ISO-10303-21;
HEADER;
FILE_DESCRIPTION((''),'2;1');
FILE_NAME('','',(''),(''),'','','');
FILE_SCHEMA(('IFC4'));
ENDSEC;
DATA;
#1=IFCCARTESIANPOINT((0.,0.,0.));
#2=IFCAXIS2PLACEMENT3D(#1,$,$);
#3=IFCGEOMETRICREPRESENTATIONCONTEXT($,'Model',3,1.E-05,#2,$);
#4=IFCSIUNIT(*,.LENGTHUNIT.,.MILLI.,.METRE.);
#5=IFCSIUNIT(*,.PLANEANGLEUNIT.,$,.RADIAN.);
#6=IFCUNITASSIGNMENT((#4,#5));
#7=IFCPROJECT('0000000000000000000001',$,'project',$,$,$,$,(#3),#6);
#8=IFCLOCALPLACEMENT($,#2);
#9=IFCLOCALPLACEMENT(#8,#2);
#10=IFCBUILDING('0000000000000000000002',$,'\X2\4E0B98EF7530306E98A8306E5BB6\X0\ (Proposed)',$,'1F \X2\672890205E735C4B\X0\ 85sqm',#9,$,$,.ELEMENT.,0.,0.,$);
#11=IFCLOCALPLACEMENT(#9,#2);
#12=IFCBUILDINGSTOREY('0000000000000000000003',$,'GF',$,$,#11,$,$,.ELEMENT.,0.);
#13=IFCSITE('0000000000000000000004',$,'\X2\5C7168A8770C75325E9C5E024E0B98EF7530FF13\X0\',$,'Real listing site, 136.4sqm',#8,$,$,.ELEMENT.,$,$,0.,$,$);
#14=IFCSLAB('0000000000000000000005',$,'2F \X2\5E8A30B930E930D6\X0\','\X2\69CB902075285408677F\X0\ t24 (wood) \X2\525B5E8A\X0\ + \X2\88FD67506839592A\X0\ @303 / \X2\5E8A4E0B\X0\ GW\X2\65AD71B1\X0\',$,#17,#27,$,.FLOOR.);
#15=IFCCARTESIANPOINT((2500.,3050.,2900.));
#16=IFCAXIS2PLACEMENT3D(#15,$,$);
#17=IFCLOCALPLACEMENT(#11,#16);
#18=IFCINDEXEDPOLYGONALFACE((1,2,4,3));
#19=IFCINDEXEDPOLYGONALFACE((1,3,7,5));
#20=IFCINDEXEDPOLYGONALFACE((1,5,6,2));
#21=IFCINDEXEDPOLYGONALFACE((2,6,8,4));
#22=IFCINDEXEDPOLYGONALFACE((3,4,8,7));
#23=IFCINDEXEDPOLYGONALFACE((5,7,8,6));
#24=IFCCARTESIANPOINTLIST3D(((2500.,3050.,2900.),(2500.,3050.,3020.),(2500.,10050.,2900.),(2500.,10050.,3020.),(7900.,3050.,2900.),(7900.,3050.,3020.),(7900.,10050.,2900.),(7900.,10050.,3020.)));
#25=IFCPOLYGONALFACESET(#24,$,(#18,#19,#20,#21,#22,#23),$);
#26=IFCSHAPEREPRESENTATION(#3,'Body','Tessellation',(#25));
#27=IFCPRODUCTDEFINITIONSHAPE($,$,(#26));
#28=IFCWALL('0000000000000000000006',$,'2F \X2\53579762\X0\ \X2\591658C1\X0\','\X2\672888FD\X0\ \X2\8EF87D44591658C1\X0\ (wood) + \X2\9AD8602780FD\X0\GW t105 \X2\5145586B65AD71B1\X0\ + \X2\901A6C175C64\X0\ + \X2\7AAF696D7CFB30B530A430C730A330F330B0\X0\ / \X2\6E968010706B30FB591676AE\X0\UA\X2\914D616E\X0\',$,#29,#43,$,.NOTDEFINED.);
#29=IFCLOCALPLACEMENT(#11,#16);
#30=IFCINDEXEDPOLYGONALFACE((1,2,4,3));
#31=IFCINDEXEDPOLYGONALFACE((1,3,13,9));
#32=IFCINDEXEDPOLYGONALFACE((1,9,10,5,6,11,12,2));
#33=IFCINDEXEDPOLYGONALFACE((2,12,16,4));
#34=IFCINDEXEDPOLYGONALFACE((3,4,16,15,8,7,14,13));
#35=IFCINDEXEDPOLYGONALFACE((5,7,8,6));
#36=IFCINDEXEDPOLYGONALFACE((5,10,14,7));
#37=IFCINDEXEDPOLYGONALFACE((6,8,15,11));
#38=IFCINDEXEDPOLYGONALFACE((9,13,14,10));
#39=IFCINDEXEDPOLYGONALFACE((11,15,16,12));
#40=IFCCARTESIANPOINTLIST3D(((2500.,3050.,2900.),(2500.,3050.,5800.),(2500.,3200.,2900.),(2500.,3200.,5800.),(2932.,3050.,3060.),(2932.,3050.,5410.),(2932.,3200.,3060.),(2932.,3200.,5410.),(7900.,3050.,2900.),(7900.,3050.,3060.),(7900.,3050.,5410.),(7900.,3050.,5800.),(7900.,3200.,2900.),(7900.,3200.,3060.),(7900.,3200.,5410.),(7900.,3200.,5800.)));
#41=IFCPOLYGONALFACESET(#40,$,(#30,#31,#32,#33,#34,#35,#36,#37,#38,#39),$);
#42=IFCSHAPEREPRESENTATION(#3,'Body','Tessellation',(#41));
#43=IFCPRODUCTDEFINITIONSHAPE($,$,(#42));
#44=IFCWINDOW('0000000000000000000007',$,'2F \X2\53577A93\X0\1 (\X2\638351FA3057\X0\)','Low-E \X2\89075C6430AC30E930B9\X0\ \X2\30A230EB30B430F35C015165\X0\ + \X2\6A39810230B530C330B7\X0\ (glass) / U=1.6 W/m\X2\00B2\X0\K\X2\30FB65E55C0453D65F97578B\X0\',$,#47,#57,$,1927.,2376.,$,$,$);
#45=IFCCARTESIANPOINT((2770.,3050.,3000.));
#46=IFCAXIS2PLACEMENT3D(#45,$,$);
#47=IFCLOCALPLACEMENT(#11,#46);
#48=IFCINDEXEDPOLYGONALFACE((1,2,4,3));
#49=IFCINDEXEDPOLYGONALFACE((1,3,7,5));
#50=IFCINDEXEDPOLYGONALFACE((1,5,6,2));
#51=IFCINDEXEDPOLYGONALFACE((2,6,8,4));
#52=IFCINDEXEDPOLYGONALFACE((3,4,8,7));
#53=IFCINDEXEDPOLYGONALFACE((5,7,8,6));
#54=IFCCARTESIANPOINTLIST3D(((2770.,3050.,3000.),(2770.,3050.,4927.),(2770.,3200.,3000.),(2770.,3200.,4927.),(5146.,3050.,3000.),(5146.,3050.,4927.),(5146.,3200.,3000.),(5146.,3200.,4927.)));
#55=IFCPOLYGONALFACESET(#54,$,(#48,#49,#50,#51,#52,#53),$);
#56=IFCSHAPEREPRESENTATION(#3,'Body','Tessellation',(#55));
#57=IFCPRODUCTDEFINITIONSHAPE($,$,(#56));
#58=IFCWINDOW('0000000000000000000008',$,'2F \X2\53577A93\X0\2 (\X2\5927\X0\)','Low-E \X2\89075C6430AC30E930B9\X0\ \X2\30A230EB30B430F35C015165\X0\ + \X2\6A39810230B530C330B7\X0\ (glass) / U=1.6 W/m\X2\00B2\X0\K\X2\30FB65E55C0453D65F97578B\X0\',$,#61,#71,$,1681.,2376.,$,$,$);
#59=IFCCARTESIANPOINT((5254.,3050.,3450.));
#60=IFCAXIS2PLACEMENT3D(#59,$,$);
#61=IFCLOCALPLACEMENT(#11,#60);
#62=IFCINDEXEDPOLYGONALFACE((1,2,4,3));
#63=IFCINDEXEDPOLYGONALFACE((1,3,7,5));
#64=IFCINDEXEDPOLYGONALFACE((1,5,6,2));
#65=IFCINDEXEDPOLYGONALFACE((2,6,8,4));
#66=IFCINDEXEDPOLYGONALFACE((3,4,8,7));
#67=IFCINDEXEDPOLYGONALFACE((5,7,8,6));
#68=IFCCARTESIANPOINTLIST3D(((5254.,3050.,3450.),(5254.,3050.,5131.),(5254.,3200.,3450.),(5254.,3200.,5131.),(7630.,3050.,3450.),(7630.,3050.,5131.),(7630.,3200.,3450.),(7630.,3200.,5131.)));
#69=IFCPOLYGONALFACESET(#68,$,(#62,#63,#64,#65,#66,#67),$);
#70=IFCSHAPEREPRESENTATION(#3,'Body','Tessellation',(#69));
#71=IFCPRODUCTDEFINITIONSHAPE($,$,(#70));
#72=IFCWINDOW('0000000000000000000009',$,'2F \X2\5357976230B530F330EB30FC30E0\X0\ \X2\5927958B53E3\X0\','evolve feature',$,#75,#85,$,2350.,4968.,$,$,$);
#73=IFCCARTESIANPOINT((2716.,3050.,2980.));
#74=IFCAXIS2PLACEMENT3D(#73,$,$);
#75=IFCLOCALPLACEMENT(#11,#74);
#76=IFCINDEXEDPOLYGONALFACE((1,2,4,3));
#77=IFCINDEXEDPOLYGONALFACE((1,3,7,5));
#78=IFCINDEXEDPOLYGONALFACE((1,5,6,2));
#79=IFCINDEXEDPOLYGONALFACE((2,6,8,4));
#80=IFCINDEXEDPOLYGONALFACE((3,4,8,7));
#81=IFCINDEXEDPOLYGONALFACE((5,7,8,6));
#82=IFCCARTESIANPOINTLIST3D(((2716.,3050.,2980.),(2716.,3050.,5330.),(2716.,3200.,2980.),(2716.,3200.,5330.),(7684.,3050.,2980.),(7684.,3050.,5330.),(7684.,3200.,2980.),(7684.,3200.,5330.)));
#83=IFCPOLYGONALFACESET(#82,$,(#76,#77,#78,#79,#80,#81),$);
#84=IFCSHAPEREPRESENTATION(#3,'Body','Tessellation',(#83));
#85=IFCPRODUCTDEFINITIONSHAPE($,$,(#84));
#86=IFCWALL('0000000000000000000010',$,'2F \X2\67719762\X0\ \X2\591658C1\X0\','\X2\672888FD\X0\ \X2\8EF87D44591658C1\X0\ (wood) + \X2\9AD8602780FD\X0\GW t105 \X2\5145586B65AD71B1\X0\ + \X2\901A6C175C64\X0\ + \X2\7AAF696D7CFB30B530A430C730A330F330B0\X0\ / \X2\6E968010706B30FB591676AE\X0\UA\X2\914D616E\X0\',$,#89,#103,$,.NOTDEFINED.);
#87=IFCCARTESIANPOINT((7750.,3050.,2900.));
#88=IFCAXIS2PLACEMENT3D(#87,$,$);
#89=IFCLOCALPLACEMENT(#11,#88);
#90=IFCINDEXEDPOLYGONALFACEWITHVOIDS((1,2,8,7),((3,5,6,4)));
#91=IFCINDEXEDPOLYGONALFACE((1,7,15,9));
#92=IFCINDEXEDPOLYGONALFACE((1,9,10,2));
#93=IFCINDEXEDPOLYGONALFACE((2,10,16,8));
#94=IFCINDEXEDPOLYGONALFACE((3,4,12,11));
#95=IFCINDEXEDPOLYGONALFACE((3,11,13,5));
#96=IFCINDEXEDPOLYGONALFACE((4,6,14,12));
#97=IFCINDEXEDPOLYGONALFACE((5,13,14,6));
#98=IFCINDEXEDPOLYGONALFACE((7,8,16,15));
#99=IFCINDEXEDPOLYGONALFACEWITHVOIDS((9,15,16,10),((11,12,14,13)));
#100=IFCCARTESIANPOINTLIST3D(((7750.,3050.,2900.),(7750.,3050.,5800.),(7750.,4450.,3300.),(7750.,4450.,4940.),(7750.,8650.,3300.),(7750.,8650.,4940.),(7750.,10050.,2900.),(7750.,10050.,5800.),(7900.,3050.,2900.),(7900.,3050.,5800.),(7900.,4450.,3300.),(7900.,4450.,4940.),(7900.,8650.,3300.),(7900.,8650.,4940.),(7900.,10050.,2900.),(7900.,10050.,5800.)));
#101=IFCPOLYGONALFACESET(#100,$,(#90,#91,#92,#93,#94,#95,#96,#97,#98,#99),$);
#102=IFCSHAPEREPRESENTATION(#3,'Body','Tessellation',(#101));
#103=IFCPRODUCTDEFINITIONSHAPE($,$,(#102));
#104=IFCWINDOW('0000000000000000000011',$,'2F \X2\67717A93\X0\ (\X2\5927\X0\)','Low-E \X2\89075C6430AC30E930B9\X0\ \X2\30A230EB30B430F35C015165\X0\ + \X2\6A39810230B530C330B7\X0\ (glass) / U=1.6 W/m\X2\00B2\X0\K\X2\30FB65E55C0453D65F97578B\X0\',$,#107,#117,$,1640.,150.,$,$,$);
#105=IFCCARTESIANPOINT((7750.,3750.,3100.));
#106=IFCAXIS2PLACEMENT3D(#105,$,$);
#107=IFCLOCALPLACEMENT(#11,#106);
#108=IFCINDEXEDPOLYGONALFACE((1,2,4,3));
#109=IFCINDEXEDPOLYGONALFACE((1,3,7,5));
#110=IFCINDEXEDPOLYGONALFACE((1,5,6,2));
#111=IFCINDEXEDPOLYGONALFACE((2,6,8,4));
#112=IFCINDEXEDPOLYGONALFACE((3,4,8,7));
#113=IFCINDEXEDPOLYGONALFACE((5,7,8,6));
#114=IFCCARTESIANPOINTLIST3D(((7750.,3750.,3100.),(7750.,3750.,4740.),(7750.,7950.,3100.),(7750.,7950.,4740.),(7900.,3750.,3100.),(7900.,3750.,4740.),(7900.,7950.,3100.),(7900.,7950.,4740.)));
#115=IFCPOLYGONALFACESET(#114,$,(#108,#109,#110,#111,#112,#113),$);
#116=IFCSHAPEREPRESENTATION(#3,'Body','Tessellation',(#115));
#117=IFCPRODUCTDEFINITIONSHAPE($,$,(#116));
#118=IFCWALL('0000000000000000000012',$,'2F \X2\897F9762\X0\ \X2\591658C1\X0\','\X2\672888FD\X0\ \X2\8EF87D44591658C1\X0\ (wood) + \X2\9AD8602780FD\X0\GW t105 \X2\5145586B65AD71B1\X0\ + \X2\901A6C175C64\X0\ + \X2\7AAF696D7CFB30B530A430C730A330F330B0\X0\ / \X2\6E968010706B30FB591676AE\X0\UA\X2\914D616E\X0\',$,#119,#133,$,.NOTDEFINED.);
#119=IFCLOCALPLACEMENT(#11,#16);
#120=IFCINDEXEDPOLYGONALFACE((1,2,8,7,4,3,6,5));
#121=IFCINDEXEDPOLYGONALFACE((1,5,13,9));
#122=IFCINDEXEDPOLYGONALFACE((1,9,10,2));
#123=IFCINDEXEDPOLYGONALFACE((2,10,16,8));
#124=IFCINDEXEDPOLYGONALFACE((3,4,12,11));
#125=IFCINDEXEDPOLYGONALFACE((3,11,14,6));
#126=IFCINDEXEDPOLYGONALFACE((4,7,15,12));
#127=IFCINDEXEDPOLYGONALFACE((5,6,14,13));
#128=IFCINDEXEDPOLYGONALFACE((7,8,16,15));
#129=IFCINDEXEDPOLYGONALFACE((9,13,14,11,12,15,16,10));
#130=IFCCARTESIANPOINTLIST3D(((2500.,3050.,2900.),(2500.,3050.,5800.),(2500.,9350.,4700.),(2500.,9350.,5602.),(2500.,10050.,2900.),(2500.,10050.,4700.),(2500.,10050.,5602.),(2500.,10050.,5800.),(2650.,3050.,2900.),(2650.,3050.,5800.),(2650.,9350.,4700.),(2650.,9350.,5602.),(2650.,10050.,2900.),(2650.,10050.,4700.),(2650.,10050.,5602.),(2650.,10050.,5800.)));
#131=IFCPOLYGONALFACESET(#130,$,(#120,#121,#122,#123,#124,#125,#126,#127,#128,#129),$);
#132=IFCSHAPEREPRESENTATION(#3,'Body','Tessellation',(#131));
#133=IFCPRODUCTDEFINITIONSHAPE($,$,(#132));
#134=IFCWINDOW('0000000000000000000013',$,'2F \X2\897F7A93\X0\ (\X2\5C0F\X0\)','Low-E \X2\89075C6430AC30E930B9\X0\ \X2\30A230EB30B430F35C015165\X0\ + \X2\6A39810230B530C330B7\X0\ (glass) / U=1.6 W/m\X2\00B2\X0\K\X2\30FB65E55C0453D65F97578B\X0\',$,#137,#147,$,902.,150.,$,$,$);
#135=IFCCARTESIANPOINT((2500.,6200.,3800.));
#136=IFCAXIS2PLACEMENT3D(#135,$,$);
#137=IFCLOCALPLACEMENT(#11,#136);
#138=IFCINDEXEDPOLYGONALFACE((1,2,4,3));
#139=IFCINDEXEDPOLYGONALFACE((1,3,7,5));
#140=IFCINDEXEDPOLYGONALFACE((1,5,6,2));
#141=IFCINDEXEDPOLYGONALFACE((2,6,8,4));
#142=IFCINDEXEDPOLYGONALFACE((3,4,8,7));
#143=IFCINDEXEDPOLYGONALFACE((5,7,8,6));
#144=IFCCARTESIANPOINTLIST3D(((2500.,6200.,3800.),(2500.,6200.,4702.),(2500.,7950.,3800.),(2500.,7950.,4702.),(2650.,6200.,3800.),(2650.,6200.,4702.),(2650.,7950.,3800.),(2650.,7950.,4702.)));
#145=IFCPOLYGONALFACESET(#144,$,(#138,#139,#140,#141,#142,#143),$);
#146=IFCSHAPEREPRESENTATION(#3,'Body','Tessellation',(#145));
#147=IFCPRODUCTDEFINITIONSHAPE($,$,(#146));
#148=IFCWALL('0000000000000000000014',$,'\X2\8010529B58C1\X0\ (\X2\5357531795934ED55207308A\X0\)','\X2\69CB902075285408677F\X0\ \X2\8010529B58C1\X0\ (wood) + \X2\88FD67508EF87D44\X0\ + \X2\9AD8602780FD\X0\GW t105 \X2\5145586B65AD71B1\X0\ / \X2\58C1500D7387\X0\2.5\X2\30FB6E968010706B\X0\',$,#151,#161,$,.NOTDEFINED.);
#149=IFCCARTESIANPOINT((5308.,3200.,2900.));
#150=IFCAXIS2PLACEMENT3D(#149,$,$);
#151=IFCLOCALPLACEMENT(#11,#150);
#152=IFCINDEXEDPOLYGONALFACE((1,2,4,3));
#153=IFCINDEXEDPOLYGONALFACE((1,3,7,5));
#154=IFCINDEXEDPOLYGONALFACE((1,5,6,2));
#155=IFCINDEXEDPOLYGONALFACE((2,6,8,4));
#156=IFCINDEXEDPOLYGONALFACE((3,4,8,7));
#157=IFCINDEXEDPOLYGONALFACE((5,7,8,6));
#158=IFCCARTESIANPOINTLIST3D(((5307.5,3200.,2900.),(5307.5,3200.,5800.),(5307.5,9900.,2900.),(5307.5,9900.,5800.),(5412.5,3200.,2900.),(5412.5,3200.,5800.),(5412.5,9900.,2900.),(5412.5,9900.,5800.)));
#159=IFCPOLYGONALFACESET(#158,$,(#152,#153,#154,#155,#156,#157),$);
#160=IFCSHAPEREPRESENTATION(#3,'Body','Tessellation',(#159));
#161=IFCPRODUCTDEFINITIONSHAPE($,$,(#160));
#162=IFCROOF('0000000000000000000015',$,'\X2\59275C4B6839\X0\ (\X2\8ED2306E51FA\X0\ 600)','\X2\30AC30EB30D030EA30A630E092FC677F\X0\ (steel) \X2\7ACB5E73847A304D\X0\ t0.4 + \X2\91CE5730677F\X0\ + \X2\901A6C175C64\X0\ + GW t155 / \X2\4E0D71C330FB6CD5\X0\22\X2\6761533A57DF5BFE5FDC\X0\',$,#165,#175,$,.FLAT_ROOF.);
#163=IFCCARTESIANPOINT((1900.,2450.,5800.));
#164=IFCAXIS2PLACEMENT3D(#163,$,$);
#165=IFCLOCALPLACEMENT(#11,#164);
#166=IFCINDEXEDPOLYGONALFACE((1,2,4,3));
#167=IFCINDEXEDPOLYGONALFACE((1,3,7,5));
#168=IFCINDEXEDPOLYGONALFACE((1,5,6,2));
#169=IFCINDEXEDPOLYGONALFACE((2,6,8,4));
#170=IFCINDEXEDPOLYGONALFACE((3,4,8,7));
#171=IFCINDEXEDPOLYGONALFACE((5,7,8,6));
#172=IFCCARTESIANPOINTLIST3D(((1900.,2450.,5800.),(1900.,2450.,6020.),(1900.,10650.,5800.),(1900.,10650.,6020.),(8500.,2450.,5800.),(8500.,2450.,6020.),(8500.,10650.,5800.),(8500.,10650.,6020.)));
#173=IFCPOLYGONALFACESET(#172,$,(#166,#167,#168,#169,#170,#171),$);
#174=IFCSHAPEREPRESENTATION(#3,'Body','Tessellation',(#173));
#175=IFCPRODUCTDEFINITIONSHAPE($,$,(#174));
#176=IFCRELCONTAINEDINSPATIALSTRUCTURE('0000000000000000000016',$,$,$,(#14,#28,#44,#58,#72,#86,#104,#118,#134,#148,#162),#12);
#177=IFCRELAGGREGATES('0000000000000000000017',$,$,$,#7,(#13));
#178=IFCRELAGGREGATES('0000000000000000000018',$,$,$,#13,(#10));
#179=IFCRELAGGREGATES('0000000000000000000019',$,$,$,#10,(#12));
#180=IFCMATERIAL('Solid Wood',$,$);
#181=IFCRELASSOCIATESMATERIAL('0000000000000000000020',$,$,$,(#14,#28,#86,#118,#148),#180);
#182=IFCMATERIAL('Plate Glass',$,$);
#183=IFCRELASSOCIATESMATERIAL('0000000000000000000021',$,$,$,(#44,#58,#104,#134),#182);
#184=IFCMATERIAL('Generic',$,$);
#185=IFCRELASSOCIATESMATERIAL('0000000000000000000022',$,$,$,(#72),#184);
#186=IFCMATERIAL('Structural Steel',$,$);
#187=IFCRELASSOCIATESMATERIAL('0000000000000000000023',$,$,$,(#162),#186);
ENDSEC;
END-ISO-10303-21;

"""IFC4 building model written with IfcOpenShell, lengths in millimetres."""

from ifc_helpers import new_model, si_unit, frame, frame_2d, origin, place, context, project, spatial, rectangle, extrude, material, element, fill, save


model = new_model("IFC4")

# Units and contexts
model_context = context("Model", 3, precision=1e-05, world=origin())
ifc_project = project(units=[si_unit("LENGTHUNIT", "METRE", prefix="MILLI"), si_unit("PLANEANGLEUNIT", "RADIAN")], contexts=[model_context])

# Site, building, storey
site_placement = place(None, origin())
site = spatial("IfcSite", under=ifc_project, at=site_placement, Name="山梨県甲府市下飯田３", ObjectType="Real listing site, 136.4sqm", CompositionType="ELEMENT", RefElevation=0.0)
building_placement = place(site_placement, origin())
building = spatial("IfcBuilding", under=site, at=building_placement, Name="下飯田の風の家 (Proposed)", ObjectType="1F 木造平屋 85sqm", CompositionType="ELEMENT", ElevationOfRefHeight=0.0, ElevationOfTerrain=0.0)
storey_placement = place(building_placement, origin())
storey = spatial("IfcBuildingStorey", under=building, at=storey_placement, Name="GF", CompositionType="ELEMENT", Elevation=0.0)

# Slab
ifc_material_1 = material(Name="Solid Wood")
slab_placement = place(storey_placement, frame((2500.0, 3050.0, 2900.0)))
element("IfcSlab", 1, at=slab_placement, inside=storey, material=ifc_material_1, Name="2F 床スラブ", Description="構造用合板 t24 (wood) 剛床 + 製材根太 @303 / 床下 GW断熱", PredefinedType="FLOOR", context=model_context, shape_type="SweptSolid", body=[
    extrude(rectangle(XDim=5400.0, YDim=7000.0, at=frame_2d((2700.0, 3500.0))), frame((2500.0, 3050.0, 2900.0)), (0.0, 0.0, 1.0), 120.0),
])

# Wall, openings, windows
wall_1_placement = place(storey_placement, frame((2500.0, 3050.0, 2900.0)))
wall_1 = element("IfcWall", 2, at=wall_1_placement, inside=storey, material=ifc_material_1, Name="2F 南面 外壁", Description="木製 軸組外壁 (wood) + 高性能GW t105 充填断熱 + 通気層 + 窯業系サイディング / 準耐火・外皮UA配慮", PredefinedType="NOTDEFINED", context=model_context, shape_type="SweptSolid", body=[
    extrude(rectangle(XDim=5400.0, YDim=150.0, at=frame_2d((2700.0, 75.0))), frame((2500.0, 3050.0, 2900.0)), (0.0, 0.0, 1.0), 2900.0),
])
opening_1_placement = place(storey_placement, frame((2770.0, 3050.0, 3000.0)))
opening_1 = element("IfcOpeningElement", 3, at=opening_1_placement, cuts=wall_1, PredefinedType="NOTDEFINED", context=model_context, shape_type="SweptSolid", body=[
    extrude(rectangle(XDim=2376.0, YDim=150.0, at=frame_2d((1188.0, 75.0))), frame((2770.0, 3050.0, 3000.0)), (0.0, 0.0, 1.0), 1927.0),
])
opening_2_placement = place(storey_placement, frame((5254.0, 3050.0, 3450.0)))
opening_2 = element("IfcOpeningElement", 4, at=opening_2_placement, cuts=wall_1, PredefinedType="NOTDEFINED", context=model_context, shape_type="SweptSolid", body=[
    extrude(rectangle(XDim=2376.0, YDim=150.0, at=frame_2d((1188.0, 75.0))), frame((5254.0, 3050.0, 3450.0)), (0.0, 0.0, 1.0), 1681.0),
])
opening_3_placement = place(storey_placement, frame((2716.0, 3050.0, 2980.0)))
opening_3 = element("IfcOpeningElement", 5, at=opening_3_placement, cuts=wall_1, PredefinedType="NOTDEFINED", context=model_context, shape_type="SweptSolid", body=[
    extrude(rectangle(XDim=4968.0, YDim=150.0, at=frame_2d((2484.0, 75.0))), frame((2716.0, 3050.0, 2980.0)), (0.0, 0.0, 1.0), 2350.0),
])
ifc_material_2 = material(Name="Plate Glass")
window_1_placement = place(storey_placement, frame((2770.0, 3050.0, 3000.0)))
window_1 = element("IfcWindow", 6, at=window_1_placement, inside=storey, material=ifc_material_2, Name="2F 南窓1 (掃出し)", Description="Low-E 複層ガラス アルゴン封入 + 樹脂サッシ (glass) / U=1.6 W/m²K・日射取得型", OverallHeight=1927.0, OverallWidth=2376.0, context=model_context, shape_type="SweptSolid", body=[
    extrude(rectangle(XDim=2376.0, YDim=150.0, at=frame_2d((1188.0, 75.0))), frame((2770.0, 3050.0, 3000.0)), (0.0, 0.0, 1.0), 1927.0),
])
fill(opening_1, window_1)
window_2_placement = place(storey_placement, frame((5254.0, 3050.0, 3450.0)))
window_2 = element("IfcWindow", 7, at=window_2_placement, inside=storey, material=ifc_material_2, Name="2F 南窓2 (大)", Description="Low-E 複層ガラス アルゴン封入 + 樹脂サッシ (glass) / U=1.6 W/m²K・日射取得型", OverallHeight=1681.0, OverallWidth=2376.0, context=model_context, shape_type="SweptSolid", body=[
    extrude(rectangle(XDim=2376.0, YDim=150.0, at=frame_2d((1188.0, 75.0))), frame((5254.0, 3050.0, 3450.0)), (0.0, 0.0, 1.0), 1681.0),
])
fill(opening_2, window_2)
ifc_material_3 = material(Name="Generic")
window_3_placement = place(storey_placement, frame((2716.0, 3050.0, 2980.0)))
window_3 = element("IfcWindow", 8, at=window_3_placement, inside=storey, material=ifc_material_3, Name="2F 南面サンルーム 大開口", Description="evolve feature", OverallHeight=2350.0, OverallWidth=4968.0, context=model_context, shape_type="SweptSolid", body=[
    extrude(rectangle(XDim=4968.0, YDim=150.0, at=frame_2d((2484.0, 75.0))), frame((2716.0, 3050.0, 2980.0)), (0.0, 0.0, 1.0), 2350.0),
])
fill(opening_3, window_3)

# Walls, openings, windows
wall_2_placement = place(storey_placement, frame((7750.0, 3050.0, 2900.0)))
wall_2 = element("IfcWall", 9, at=wall_2_placement, inside=storey, material=ifc_material_1, Name="2F 東面 外壁", Description="木製 軸組外壁 (wood) + 高性能GW t105 充填断熱 + 通気層 + 窯業系サイディング / 準耐火・外皮UA配慮", PredefinedType="NOTDEFINED", context=model_context, shape_type="SweptSolid", body=[
    extrude(rectangle(XDim=150.0, YDim=7000.0, at=frame_2d((75.0, 3500.0))), frame((7750.0, 3050.0, 2900.0)), (0.0, 0.0, 1.0), 2900.0),
])
opening_4_placement = place(storey_placement, frame((7750.0, 3750.0, 3100.0)))
opening_4 = element("IfcOpeningElement", 10, at=opening_4_placement, cuts=wall_2, PredefinedType="NOTDEFINED", context=model_context, shape_type="SweptSolid", body=[
    extrude(rectangle(XDim=150.0, YDim=4200.0, at=frame_2d((75.0, 2100.0))), frame((7750.0, 3750.0, 3100.0)), (0.0, 0.0, 1.0), 1640.0),
])
window_4_placement = place(storey_placement, frame((7750.0, 3750.0, 3100.0)))
window_4 = element("IfcWindow", 11, at=window_4_placement, inside=storey, material=ifc_material_2, Name="2F 東窓 (大)", Description="Low-E 複層ガラス アルゴン封入 + 樹脂サッシ (glass) / U=1.6 W/m²K・日射取得型", OverallHeight=1640.0, OverallWidth=150.0, context=model_context, shape_type="SweptSolid", body=[
    extrude(rectangle(XDim=150.0, YDim=4200.0, at=frame_2d((75.0, 2100.0))), frame((7750.0, 3750.0, 3100.0)), (0.0, 0.0, 1.0), 1640.0),
])
fill(opening_4, window_4)
wall_3_placement = place(storey_placement, frame((2500.0, 3050.0, 2900.0)))
wall_3 = element("IfcWall", 12, at=wall_3_placement, inside=storey, material=ifc_material_1, Name="2F 西面 外壁", Description="木製 軸組外壁 (wood) + 高性能GW t105 充填断熱 + 通気層 + 窯業系サイディング / 準耐火・外皮UA配慮", PredefinedType="NOTDEFINED", context=model_context, shape_type="SweptSolid", body=[
    extrude(rectangle(XDim=150.0, YDim=7000.0, at=frame_2d((75.0, 3500.0))), frame((2500.0, 3050.0, 2900.0)), (0.0, 0.0, 1.0), 2900.0),
])
opening_5_placement = place(storey_placement, frame((2500.0, 6200.0, 3800.0)))
opening_5 = element("IfcOpeningElement", 13, at=opening_5_placement, cuts=wall_3, PredefinedType="NOTDEFINED", context=model_context, shape_type="SweptSolid", body=[
    extrude(rectangle(XDim=150.0, YDim=1750.0, at=frame_2d((75.0, 875.0))), frame((2500.0, 6200.0, 3800.0)), (0.0, 0.0, 1.0), 902.0),
])
window_5_placement = place(storey_placement, frame((2500.0, 6200.0, 3800.0)))
window_5 = element("IfcWindow", 14, at=window_5_placement, inside=storey, material=ifc_material_2, Name="2F 西窓 (小)", Description="Low-E 複層ガラス アルゴン封入 + 樹脂サッシ (glass) / U=1.6 W/m²K・日射取得型", OverallHeight=902.0, OverallWidth=150.0, context=model_context, shape_type="SweptSolid", body=[
    extrude(rectangle(XDim=150.0, YDim=1750.0, at=frame_2d((75.0, 875.0))), frame((2500.0, 6200.0, 3800.0)), (0.0, 0.0, 1.0), 902.0),
])
fill(opening_5, window_5)

# Wall
wall_4_placement = place(storey_placement, frame((5308.0, 3200.0, 2900.0)))
element("IfcWall", 15, at=wall_4_placement, inside=storey, material=ifc_material_1, Name="耐力壁 (南北間仕切り)", Description="構造用合板 耐力壁 (wood) + 製材軸組 + 高性能GW t105 充填断熱 / 壁倍率2.5・準耐火", PredefinedType="NOTDEFINED", context=model_context, shape_type="SweptSolid", body=[
    extrude(rectangle(XDim=105.0, YDim=6700.0, at=frame_2d((52.0, 3350.0))), frame((5308.0, 3200.0, 2900.0)), (0.0, 0.0, 1.0), 2900.0),
])

# Roof
ifc_material_4 = material(Name="Structural Steel")
roof_1_placement = place(storey_placement, frame((1900.0, 2450.0, 5800.0)))
element("IfcRoof", 16, at=roof_1_placement, inside=storey, material=ifc_material_4, Name="大屋根 (軒の出 600)", Description="ガルバリウム鋼板 (steel) 立平葺き t0.4 + 野地板 + 通気層 + GW t155 / 不燃・法22条区域対応", PredefinedType="FLAT_ROOF", context=model_context, shape_type="SweptSolid", body=[
    extrude(rectangle(XDim=6600.0, YDim=8200.0, at=frame_2d((3300.0, 4100.0))), frame((1900.0, 2450.0, 5800.0)), (0.0, 0.0, 1.0), 220.0),
])

save(model, "model.ifc")
